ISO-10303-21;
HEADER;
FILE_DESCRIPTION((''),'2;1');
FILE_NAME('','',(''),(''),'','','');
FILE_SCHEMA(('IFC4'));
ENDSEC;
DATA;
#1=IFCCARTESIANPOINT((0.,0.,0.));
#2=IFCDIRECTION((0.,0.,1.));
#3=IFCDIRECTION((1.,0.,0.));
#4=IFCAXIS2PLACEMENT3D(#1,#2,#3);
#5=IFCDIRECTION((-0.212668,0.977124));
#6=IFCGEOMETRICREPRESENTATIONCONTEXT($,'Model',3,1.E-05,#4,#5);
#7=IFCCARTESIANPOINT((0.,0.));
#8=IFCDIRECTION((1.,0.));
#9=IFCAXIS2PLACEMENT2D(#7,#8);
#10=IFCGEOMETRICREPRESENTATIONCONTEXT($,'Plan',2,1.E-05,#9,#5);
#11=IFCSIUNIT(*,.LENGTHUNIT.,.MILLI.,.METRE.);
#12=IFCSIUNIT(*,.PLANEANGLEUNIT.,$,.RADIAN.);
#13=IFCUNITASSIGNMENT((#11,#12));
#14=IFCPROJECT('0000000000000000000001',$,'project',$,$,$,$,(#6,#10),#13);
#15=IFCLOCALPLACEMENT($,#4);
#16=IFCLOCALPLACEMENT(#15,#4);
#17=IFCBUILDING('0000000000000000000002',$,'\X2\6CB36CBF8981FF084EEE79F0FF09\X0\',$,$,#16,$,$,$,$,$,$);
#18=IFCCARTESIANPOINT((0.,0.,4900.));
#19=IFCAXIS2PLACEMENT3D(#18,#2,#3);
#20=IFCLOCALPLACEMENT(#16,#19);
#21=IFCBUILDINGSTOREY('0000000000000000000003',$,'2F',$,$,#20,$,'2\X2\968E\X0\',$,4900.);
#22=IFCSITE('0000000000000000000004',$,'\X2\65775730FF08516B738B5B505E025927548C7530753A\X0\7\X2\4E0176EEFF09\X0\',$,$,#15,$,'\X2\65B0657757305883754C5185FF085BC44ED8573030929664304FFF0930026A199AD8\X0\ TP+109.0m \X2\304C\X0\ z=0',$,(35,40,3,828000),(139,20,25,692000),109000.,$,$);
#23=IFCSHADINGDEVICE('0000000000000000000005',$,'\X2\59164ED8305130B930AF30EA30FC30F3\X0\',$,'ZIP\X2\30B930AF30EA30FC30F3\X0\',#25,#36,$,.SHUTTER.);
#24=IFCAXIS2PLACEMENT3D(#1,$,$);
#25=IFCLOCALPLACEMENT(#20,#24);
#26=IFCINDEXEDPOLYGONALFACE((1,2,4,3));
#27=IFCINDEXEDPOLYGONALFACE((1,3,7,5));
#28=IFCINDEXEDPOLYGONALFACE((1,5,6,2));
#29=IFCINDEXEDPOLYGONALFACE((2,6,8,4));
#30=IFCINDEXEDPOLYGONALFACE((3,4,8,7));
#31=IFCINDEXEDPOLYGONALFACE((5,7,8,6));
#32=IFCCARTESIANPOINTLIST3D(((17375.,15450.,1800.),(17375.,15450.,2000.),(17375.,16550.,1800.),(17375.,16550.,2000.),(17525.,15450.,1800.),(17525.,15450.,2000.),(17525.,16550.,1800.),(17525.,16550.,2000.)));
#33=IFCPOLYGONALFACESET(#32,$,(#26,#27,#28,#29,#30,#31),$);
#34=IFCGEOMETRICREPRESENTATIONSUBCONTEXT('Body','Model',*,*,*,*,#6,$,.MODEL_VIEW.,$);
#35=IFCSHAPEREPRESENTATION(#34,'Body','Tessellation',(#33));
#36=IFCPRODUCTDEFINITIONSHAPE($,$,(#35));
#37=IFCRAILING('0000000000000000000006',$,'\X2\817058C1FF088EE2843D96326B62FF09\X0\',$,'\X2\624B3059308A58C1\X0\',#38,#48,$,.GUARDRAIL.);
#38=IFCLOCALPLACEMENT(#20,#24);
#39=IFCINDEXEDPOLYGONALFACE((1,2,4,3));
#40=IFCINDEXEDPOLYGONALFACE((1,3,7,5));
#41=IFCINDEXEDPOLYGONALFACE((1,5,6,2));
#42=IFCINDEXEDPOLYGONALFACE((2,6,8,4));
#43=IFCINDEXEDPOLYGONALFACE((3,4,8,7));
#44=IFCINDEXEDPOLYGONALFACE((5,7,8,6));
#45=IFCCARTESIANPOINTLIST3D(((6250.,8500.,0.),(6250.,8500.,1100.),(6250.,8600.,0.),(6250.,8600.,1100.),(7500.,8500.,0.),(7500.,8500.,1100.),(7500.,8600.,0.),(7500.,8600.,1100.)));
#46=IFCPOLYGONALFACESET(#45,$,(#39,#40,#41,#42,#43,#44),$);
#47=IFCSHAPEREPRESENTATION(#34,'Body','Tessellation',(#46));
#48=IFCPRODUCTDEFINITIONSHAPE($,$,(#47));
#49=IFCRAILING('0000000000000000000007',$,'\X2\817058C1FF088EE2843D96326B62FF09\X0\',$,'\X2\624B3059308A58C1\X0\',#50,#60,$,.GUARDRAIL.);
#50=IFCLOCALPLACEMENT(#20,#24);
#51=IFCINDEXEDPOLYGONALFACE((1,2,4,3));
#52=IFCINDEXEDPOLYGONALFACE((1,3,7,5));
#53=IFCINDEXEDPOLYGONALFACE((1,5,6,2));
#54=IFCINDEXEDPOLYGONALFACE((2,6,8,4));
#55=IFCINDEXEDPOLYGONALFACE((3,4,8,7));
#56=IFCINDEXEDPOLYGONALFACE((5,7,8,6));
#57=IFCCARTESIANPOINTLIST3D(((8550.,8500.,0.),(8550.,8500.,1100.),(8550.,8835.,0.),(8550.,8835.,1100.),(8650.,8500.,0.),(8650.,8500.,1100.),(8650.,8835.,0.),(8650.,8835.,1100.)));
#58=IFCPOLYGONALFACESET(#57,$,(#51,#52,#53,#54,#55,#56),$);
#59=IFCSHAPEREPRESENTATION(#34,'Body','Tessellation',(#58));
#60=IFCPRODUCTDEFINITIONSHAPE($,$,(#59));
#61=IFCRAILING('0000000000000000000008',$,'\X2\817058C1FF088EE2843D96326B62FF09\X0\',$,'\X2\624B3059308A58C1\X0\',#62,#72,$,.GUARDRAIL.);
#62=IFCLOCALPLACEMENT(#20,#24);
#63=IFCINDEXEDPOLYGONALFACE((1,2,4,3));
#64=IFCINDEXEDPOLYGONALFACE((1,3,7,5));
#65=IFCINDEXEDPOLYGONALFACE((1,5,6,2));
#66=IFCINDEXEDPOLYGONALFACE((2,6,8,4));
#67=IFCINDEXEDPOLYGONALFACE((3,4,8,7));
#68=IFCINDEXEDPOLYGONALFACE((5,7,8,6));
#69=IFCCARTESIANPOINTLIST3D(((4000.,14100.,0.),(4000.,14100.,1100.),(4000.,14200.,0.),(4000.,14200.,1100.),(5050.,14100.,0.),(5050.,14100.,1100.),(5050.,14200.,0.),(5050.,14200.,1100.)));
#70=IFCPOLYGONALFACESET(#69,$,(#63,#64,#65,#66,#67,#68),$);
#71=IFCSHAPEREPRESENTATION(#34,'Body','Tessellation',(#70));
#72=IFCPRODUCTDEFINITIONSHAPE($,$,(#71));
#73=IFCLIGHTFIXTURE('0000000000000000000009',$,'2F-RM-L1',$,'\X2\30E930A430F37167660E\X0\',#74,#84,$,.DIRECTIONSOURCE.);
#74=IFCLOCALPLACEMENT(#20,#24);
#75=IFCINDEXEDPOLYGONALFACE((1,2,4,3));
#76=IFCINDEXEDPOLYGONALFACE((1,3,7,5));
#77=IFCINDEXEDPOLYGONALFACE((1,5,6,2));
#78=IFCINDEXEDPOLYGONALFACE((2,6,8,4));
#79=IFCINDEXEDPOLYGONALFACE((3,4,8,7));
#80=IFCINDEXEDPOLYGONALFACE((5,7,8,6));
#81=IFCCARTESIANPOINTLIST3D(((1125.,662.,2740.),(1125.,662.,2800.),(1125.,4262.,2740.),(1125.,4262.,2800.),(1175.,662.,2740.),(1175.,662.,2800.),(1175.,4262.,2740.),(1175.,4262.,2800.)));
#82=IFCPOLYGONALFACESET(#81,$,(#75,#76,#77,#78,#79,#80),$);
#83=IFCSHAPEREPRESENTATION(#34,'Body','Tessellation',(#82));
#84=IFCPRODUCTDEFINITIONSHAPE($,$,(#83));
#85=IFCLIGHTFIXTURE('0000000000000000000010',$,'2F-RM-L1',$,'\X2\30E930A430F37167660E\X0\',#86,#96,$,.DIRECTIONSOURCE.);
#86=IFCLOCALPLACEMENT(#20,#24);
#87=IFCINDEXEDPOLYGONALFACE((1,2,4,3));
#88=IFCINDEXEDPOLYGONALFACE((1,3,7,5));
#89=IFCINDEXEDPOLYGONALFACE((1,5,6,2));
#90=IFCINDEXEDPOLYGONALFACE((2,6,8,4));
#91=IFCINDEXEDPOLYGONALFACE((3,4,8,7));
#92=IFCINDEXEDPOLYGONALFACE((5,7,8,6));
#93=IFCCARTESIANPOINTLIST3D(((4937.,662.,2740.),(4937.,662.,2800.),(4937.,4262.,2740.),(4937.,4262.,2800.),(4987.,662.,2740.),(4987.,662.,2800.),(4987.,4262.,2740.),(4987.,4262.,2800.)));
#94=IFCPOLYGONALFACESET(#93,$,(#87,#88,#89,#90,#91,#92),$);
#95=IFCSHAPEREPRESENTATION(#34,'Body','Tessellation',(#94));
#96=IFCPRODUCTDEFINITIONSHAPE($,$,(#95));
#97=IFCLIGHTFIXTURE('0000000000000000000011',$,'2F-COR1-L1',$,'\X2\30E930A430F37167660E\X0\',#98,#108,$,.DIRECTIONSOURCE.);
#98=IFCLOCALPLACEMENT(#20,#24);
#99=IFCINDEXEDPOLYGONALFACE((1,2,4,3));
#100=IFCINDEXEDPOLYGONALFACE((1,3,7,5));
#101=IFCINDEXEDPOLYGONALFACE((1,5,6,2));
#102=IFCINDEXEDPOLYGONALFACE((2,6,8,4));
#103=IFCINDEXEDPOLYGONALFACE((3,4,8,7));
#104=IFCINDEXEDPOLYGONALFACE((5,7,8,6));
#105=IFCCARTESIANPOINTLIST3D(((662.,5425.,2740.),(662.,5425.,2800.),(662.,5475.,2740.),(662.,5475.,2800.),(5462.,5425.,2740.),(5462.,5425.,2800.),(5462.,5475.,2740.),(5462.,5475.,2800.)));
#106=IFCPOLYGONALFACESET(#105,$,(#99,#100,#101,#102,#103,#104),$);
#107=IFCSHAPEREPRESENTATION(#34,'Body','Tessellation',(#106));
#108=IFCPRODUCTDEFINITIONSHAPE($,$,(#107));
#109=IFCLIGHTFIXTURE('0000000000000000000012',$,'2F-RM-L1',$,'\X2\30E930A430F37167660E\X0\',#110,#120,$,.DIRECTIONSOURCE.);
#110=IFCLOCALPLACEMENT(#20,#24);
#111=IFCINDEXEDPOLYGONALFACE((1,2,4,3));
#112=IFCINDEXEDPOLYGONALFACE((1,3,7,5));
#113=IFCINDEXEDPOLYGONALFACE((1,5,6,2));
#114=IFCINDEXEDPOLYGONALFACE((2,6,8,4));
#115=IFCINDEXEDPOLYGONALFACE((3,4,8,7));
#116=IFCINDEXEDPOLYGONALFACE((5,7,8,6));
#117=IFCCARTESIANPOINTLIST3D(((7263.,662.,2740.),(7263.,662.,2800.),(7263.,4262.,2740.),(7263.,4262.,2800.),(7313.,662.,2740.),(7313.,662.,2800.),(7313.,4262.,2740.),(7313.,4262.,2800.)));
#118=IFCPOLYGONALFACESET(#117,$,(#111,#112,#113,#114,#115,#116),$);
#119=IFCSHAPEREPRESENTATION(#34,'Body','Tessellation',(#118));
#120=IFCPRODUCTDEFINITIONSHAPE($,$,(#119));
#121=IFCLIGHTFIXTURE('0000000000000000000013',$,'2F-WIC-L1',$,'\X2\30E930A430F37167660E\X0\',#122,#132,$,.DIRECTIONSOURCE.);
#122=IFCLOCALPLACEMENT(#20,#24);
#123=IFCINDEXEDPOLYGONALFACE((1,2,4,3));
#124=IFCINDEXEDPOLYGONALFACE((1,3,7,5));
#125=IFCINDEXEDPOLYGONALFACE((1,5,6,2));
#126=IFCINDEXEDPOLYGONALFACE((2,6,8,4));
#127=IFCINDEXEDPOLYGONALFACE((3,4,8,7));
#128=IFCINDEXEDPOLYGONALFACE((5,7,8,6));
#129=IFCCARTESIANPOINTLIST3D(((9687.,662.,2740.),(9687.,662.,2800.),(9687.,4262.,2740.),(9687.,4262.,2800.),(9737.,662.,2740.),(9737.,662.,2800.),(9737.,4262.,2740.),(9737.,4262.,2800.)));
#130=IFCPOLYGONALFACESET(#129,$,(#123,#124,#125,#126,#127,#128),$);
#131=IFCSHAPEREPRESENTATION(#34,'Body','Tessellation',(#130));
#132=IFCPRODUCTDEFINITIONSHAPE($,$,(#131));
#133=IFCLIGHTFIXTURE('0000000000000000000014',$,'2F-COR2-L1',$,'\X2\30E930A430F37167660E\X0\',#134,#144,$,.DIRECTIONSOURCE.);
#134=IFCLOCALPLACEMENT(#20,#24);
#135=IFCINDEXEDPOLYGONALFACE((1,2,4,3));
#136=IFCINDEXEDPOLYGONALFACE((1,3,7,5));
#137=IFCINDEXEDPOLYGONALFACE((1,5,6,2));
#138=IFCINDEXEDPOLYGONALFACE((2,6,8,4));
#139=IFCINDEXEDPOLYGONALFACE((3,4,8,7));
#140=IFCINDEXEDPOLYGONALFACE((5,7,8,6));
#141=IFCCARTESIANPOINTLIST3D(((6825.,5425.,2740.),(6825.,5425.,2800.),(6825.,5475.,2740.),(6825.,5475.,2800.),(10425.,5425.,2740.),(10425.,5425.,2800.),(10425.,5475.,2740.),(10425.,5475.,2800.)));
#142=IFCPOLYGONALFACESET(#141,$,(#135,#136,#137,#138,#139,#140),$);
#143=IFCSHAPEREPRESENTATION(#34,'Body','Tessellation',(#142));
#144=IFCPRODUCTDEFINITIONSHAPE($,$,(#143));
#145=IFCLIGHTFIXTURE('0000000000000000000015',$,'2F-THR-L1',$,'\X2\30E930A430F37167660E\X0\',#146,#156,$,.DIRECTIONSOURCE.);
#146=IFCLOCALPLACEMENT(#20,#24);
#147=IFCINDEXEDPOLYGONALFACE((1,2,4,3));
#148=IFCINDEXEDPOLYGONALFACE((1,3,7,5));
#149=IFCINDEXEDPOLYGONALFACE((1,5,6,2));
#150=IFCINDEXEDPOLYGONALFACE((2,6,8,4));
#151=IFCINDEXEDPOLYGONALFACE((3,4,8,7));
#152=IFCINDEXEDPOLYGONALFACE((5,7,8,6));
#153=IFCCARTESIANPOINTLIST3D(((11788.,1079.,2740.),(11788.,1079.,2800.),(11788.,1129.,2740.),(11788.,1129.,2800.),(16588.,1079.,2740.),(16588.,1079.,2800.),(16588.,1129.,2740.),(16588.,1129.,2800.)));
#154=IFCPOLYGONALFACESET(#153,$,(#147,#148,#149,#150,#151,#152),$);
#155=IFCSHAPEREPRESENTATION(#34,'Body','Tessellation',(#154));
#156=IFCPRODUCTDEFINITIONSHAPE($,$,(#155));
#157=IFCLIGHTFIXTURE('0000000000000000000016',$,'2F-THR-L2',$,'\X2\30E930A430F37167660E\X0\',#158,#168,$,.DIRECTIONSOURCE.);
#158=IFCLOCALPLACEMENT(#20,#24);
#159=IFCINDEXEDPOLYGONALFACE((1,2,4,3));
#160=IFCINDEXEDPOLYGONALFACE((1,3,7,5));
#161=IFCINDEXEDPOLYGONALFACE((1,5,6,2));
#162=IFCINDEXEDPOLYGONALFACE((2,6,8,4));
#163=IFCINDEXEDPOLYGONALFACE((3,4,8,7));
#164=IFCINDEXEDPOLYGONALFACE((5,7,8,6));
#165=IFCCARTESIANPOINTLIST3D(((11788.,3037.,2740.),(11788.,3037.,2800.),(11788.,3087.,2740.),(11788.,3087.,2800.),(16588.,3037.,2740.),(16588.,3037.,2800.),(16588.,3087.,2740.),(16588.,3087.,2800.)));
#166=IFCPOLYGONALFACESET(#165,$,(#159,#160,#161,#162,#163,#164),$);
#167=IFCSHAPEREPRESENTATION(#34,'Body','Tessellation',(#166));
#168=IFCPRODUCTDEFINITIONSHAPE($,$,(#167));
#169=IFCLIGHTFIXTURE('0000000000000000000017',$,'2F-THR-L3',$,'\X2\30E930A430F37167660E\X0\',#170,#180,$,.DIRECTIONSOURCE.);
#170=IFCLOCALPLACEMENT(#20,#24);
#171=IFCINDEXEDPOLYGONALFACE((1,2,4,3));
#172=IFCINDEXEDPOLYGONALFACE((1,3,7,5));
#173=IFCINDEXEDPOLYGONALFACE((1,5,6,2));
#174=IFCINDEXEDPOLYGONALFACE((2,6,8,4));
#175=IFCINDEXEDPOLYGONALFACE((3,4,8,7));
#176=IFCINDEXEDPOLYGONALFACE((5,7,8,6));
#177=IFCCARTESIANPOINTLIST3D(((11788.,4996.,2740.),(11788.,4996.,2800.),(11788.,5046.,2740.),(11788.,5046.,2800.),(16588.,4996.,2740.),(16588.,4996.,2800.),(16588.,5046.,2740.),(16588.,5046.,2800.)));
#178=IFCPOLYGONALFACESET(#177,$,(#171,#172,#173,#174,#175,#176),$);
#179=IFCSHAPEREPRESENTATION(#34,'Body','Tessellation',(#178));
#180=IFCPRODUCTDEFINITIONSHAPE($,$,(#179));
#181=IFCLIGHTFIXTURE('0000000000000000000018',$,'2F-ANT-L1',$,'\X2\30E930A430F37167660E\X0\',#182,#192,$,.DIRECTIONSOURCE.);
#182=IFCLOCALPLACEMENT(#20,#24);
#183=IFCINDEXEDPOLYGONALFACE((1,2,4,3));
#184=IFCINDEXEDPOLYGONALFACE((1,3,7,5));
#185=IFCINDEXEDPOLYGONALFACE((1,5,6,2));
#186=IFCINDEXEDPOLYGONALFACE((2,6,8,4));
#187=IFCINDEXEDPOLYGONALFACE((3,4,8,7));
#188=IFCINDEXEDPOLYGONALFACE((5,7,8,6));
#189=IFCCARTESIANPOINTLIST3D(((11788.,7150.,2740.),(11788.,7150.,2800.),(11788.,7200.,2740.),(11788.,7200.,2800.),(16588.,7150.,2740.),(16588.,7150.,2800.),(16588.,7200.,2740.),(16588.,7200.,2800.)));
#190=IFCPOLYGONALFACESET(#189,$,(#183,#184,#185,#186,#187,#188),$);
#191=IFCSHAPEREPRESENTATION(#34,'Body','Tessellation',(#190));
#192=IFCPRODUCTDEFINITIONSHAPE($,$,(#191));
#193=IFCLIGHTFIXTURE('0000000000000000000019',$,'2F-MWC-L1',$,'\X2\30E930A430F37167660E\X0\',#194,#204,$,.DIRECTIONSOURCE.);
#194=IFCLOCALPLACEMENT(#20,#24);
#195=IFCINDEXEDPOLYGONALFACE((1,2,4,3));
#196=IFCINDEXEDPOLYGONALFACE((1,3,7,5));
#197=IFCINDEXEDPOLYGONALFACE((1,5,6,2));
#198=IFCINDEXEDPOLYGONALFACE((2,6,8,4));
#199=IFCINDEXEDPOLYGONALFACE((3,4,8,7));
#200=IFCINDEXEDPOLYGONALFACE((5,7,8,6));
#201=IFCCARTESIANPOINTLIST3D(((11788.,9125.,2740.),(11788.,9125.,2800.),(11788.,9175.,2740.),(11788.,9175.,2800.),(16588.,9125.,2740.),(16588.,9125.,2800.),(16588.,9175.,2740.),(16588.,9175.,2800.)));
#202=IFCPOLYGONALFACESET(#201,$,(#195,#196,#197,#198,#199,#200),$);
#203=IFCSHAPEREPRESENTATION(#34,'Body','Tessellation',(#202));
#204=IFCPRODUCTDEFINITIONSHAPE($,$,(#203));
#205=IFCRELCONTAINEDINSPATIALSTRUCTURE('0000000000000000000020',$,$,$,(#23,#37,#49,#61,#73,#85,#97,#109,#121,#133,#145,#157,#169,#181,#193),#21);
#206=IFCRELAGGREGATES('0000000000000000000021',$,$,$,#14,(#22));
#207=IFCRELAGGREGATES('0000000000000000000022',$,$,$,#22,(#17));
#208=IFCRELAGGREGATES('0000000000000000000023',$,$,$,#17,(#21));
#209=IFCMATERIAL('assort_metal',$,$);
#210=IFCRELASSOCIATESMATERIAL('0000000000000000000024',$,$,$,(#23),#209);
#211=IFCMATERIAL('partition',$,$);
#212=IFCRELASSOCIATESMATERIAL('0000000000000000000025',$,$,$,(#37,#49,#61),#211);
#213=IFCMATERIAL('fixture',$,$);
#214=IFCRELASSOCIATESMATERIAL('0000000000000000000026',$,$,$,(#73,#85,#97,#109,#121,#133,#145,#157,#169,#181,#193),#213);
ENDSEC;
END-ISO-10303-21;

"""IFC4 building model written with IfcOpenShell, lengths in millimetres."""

from ifc_helpers import new_model, si_unit, direction, frame, frame_2d, origin, origin_with_axes, origin_2d_with_axis, place, context, subcontext, project, spatial, rectangle, extrude, material, element, save


model = new_model("IFC4")

# Units and contexts
model_context = context("Model", 3, precision=1e-05, world=origin_with_axes(), true_north=direction((-0.212668, 0.977124)))
plan_context = context("Plan", 2, precision=1e-05, world=origin_2d_with_axis(), true_north=direction((-0.212668, 0.977124)))
body_context = subcontext(model_context, "Body", "Model", "MODEL_VIEW")
ifc_project = project(units=[si_unit("LENGTHUNIT", "METRE", prefix="MILLI"), si_unit("PLANEANGLEUNIT", "RADIAN")], contexts=[model_context, plan_context])

# Site, building, storey
site_placement = place(None, origin_with_axes())
site = spatial("IfcSite", under=ifc_project, at=site_placement, Name="敷地（八王子市大和田町7丁目）", LongName="新敷地境界内（寄付地を除く）。標高 TP+109.0m が z=0", RefLatitude=(35, 40, 3, 828000), RefLongitude=(139, 20, 25, 692000), RefElevation=109000.0)
building_placement = place(site_placement, origin_with_axes())
building = spatial("IfcBuilding", under=site, at=building_placement, Name="河沿要（仮称）")
storey_placement = place(building_placement, frame((0.0, 0.0, 4900.0), z_axis=(0.0, 0.0, 1.0), x_axis=(1.0, 0.0, 0.0)))
storey = spatial("IfcBuildingStorey", under=building, at=storey_placement, Name="2F", LongName="2階", Elevation=4900.0)

# Shading device
ifc_material_1 = material(Name="assort_metal")
shading_device_placement = place(storey_placement, origin_with_axes())
element("IfcShadingDevice", 1, at=shading_device_placement, inside=storey, material=ifc_material_1, Name="外付けスクリーン", ObjectType="ZIPスクリーン", PredefinedType="SHUTTER", context=body_context, shape_type="SweptSolid", body=[
    extrude(rectangle(XDim=150.0, YDim=1100.0, at=frame_2d((17450.0, 16000.0))), frame((0.0, 0.0, 1800.0)), (0.0, 0.0, 1.0), 200.0),
])

# Railings
ifc_material_2 = material(Name="partition")
railing_1_placement = place(storey_placement, origin_with_axes())
element("IfcRailing", 2, at=railing_1_placement, inside=storey, material=ifc_material_2, Name="腰壁（転落防止）", ObjectType="手すり壁", PredefinedType="GUARDRAIL", context=body_context, shape_type="SweptSolid", body=[
    extrude(rectangle(XDim=1250.0, YDim=100.0, at=frame_2d((6875.0, 8550.0))), origin(), (0.0, 0.0, 1.0), 1100.0),
])
railing_2_placement = place(storey_placement, origin_with_axes())
element("IfcRailing", 3, at=railing_2_placement, inside=storey, material=ifc_material_2, Name="腰壁（転落防止）", ObjectType="手すり壁", PredefinedType="GUARDRAIL", context=body_context, shape_type="SweptSolid", body=[
    extrude(rectangle(XDim=100.0, YDim=335.0, at=frame_2d((8600.0, 8667.5))), origin(), (0.0, 0.0, 1.0), 1100.0),
])
railing_3_placement = place(storey_placement, origin_with_axes())
element("IfcRailing", 4, at=railing_3_placement, inside=storey, material=ifc_material_2, Name="腰壁（転落防止）", ObjectType="手すり壁", PredefinedType="GUARDRAIL", context=body_context, shape_type="SweptSolid", body=[
    extrude(rectangle(XDim=1050.0, YDim=100.0, at=frame_2d((4525.0, 14150.0))), origin(), (0.0, 0.0, 1.0), 1100.0),
])

# Light fixtures
ifc_material_3 = material(Name="fixture")
light_fixture_1_placement = place(storey_placement, origin_with_axes())
element("IfcLightFixture", 5, at=light_fixture_1_placement, inside=storey, material=ifc_material_3, Name="2F-RM-L1", ObjectType="ライン照明", PredefinedType="DIRECTIONSOURCE", context=body_context, shape_type="SweptSolid", body=[
    extrude(rectangle(XDim=50.0, YDim=3600.0, at=frame_2d((1150.0, 2462.0))), frame((0.0, 0.0, 2740.0)), (0.0, 0.0, 1.0), 60.0),
])
light_fixture_2_placement = place(storey_placement, origin_with_axes())
element("IfcLightFixture", 6, at=light_fixture_2_placement, inside=storey, material=ifc_material_3, Name="2F-RM-L1", ObjectType="ライン照明", PredefinedType="DIRECTIONSOURCE", context=body_context, shape_type="SweptSolid", body=[
    extrude(rectangle(XDim=50.0, YDim=3600.0, at=frame_2d((4962.0, 2462.0))), frame((0.0, 0.0, 2740.0)), (0.0, 0.0, 1.0), 60.0),
])
light_fixture_3_placement = place(storey_placement, origin_with_axes())
element("IfcLightFixture", 7, at=light_fixture_3_placement, inside=storey, material=ifc_material_3, Name="2F-COR1-L1", ObjectType="ライン照明", PredefinedType="DIRECTIONSOURCE", context=body_context, shape_type="SweptSolid", body=[
    extrude(rectangle(XDim=4800.0, YDim=50.0, at=frame_2d((3062.0, 5450.0))), frame((0.0, 0.0, 2740.0)), (0.0, 0.0, 1.0), 60.0),
])
light_fixture_4_placement = place(storey_placement, origin_with_axes())
element("IfcLightFixture", 8, at=light_fixture_4_placement, inside=storey, material=ifc_material_3, Name="2F-RM-L1", ObjectType="ライン照明", PredefinedType="DIRECTIONSOURCE", context=body_context, shape_type="SweptSolid", body=[
    extrude(rectangle(XDim=50.0, YDim=3600.0, at=frame_2d((7288.0, 2462.0))), frame((0.0, 0.0, 2740.0)), (0.0, 0.0, 1.0), 60.0),
])
light_fixture_5_placement = place(storey_placement, origin_with_axes())
element("IfcLightFixture", 9, at=light_fixture_5_placement, inside=storey, material=ifc_material_3, Name="2F-WIC-L1", ObjectType="ライン照明", PredefinedType="DIRECTIONSOURCE", context=body_context, shape_type="SweptSolid", body=[
    extrude(rectangle(XDim=50.0, YDim=3600.0, at=frame_2d((9712.0, 2462.0))), frame((0.0, 0.0, 2740.0)), (0.0, 0.0, 1.0), 60.0),
])
light_fixture_6_placement = place(storey_placement, origin_with_axes())
element("IfcLightFixture", 10, at=light_fixture_6_placement, inside=storey, material=ifc_material_3, Name="2F-COR2-L1", ObjectType="ライン照明", PredefinedType="DIRECTIONSOURCE", context=body_context, shape_type="SweptSolid", body=[
    extrude(rectangle(XDim=3600.0, YDim=50.0, at=frame_2d((8625.0, 5450.0))), frame((0.0, 0.0, 2740.0)), (0.0, 0.0, 1.0), 60.0),
])
light_fixture_7_placement = place(storey_placement, origin_with_axes())
element("IfcLightFixture", 11, at=light_fixture_7_placement, inside=storey, material=ifc_material_3, Name="2F-THR-L1", ObjectType="ライン照明", PredefinedType="DIRECTIONSOURCE", context=body_context, shape_type="SweptSolid", body=[
    extrude(rectangle(XDim=4800.0, YDim=50.0, at=frame_2d((14188.0, 1104.0))), frame((0.0, 0.0, 2740.0)), (0.0, 0.0, 1.0), 60.0),
])
light_fixture_8_placement = place(storey_placement, origin_with_axes())
element("IfcLightFixture", 12, at=light_fixture_8_placement, inside=storey, material=ifc_material_3, Name="2F-THR-L2", ObjectType="ライン照明", PredefinedType="DIRECTIONSOURCE", context=body_context, shape_type="SweptSolid", body=[
    extrude(rectangle(XDim=4800.0, YDim=50.0, at=frame_2d((14188.0, 3062.0))), frame((0.0, 0.0, 2740.0)), (0.0, 0.0, 1.0), 60.0),
])
light_fixture_9_placement = place(storey_placement, origin_with_axes())
element("IfcLightFixture", 13, at=light_fixture_9_placement, inside=storey, material=ifc_material_3, Name="2F-THR-L3", ObjectType="ライン照明", PredefinedType="DIRECTIONSOURCE", context=body_context, shape_type="SweptSolid", body=[
    extrude(rectangle(XDim=4800.0, YDim=50.0, at=frame_2d((14188.0, 5021.0))), frame((0.0, 0.0, 2740.0)), (0.0, 0.0, 1.0), 60.0),
])
light_fixture_10_placement = place(storey_placement, origin_with_axes())
element("IfcLightFixture", 14, at=light_fixture_10_placement, inside=storey, material=ifc_material_3, Name="2F-ANT-L1", ObjectType="ライン照明", PredefinedType="DIRECTIONSOURCE", context=body_context, shape_type="SweptSolid", body=[
    extrude(rectangle(XDim=4800.0, YDim=50.0, at=frame_2d((14188.0, 7175.0))), frame((0.0, 0.0, 2740.0)), (0.0, 0.0, 1.0), 60.0),
])
light_fixture_11_placement = place(storey_placement, origin_with_axes())
element("IfcLightFixture", 15, at=light_fixture_11_placement, inside=storey, material=ifc_material_3, Name="2F-MWC-L1", ObjectType="ライン照明", PredefinedType="DIRECTIONSOURCE", context=body_context, shape_type="SweptSolid", body=[
    extrude(rectangle(XDim=4800.0, YDim=50.0, at=frame_2d((14188.0, 9150.0))), frame((0.0, 0.0, 2740.0)), (0.0, 0.0, 1.0), 60.0),
])

save(model, "model.ifc")
